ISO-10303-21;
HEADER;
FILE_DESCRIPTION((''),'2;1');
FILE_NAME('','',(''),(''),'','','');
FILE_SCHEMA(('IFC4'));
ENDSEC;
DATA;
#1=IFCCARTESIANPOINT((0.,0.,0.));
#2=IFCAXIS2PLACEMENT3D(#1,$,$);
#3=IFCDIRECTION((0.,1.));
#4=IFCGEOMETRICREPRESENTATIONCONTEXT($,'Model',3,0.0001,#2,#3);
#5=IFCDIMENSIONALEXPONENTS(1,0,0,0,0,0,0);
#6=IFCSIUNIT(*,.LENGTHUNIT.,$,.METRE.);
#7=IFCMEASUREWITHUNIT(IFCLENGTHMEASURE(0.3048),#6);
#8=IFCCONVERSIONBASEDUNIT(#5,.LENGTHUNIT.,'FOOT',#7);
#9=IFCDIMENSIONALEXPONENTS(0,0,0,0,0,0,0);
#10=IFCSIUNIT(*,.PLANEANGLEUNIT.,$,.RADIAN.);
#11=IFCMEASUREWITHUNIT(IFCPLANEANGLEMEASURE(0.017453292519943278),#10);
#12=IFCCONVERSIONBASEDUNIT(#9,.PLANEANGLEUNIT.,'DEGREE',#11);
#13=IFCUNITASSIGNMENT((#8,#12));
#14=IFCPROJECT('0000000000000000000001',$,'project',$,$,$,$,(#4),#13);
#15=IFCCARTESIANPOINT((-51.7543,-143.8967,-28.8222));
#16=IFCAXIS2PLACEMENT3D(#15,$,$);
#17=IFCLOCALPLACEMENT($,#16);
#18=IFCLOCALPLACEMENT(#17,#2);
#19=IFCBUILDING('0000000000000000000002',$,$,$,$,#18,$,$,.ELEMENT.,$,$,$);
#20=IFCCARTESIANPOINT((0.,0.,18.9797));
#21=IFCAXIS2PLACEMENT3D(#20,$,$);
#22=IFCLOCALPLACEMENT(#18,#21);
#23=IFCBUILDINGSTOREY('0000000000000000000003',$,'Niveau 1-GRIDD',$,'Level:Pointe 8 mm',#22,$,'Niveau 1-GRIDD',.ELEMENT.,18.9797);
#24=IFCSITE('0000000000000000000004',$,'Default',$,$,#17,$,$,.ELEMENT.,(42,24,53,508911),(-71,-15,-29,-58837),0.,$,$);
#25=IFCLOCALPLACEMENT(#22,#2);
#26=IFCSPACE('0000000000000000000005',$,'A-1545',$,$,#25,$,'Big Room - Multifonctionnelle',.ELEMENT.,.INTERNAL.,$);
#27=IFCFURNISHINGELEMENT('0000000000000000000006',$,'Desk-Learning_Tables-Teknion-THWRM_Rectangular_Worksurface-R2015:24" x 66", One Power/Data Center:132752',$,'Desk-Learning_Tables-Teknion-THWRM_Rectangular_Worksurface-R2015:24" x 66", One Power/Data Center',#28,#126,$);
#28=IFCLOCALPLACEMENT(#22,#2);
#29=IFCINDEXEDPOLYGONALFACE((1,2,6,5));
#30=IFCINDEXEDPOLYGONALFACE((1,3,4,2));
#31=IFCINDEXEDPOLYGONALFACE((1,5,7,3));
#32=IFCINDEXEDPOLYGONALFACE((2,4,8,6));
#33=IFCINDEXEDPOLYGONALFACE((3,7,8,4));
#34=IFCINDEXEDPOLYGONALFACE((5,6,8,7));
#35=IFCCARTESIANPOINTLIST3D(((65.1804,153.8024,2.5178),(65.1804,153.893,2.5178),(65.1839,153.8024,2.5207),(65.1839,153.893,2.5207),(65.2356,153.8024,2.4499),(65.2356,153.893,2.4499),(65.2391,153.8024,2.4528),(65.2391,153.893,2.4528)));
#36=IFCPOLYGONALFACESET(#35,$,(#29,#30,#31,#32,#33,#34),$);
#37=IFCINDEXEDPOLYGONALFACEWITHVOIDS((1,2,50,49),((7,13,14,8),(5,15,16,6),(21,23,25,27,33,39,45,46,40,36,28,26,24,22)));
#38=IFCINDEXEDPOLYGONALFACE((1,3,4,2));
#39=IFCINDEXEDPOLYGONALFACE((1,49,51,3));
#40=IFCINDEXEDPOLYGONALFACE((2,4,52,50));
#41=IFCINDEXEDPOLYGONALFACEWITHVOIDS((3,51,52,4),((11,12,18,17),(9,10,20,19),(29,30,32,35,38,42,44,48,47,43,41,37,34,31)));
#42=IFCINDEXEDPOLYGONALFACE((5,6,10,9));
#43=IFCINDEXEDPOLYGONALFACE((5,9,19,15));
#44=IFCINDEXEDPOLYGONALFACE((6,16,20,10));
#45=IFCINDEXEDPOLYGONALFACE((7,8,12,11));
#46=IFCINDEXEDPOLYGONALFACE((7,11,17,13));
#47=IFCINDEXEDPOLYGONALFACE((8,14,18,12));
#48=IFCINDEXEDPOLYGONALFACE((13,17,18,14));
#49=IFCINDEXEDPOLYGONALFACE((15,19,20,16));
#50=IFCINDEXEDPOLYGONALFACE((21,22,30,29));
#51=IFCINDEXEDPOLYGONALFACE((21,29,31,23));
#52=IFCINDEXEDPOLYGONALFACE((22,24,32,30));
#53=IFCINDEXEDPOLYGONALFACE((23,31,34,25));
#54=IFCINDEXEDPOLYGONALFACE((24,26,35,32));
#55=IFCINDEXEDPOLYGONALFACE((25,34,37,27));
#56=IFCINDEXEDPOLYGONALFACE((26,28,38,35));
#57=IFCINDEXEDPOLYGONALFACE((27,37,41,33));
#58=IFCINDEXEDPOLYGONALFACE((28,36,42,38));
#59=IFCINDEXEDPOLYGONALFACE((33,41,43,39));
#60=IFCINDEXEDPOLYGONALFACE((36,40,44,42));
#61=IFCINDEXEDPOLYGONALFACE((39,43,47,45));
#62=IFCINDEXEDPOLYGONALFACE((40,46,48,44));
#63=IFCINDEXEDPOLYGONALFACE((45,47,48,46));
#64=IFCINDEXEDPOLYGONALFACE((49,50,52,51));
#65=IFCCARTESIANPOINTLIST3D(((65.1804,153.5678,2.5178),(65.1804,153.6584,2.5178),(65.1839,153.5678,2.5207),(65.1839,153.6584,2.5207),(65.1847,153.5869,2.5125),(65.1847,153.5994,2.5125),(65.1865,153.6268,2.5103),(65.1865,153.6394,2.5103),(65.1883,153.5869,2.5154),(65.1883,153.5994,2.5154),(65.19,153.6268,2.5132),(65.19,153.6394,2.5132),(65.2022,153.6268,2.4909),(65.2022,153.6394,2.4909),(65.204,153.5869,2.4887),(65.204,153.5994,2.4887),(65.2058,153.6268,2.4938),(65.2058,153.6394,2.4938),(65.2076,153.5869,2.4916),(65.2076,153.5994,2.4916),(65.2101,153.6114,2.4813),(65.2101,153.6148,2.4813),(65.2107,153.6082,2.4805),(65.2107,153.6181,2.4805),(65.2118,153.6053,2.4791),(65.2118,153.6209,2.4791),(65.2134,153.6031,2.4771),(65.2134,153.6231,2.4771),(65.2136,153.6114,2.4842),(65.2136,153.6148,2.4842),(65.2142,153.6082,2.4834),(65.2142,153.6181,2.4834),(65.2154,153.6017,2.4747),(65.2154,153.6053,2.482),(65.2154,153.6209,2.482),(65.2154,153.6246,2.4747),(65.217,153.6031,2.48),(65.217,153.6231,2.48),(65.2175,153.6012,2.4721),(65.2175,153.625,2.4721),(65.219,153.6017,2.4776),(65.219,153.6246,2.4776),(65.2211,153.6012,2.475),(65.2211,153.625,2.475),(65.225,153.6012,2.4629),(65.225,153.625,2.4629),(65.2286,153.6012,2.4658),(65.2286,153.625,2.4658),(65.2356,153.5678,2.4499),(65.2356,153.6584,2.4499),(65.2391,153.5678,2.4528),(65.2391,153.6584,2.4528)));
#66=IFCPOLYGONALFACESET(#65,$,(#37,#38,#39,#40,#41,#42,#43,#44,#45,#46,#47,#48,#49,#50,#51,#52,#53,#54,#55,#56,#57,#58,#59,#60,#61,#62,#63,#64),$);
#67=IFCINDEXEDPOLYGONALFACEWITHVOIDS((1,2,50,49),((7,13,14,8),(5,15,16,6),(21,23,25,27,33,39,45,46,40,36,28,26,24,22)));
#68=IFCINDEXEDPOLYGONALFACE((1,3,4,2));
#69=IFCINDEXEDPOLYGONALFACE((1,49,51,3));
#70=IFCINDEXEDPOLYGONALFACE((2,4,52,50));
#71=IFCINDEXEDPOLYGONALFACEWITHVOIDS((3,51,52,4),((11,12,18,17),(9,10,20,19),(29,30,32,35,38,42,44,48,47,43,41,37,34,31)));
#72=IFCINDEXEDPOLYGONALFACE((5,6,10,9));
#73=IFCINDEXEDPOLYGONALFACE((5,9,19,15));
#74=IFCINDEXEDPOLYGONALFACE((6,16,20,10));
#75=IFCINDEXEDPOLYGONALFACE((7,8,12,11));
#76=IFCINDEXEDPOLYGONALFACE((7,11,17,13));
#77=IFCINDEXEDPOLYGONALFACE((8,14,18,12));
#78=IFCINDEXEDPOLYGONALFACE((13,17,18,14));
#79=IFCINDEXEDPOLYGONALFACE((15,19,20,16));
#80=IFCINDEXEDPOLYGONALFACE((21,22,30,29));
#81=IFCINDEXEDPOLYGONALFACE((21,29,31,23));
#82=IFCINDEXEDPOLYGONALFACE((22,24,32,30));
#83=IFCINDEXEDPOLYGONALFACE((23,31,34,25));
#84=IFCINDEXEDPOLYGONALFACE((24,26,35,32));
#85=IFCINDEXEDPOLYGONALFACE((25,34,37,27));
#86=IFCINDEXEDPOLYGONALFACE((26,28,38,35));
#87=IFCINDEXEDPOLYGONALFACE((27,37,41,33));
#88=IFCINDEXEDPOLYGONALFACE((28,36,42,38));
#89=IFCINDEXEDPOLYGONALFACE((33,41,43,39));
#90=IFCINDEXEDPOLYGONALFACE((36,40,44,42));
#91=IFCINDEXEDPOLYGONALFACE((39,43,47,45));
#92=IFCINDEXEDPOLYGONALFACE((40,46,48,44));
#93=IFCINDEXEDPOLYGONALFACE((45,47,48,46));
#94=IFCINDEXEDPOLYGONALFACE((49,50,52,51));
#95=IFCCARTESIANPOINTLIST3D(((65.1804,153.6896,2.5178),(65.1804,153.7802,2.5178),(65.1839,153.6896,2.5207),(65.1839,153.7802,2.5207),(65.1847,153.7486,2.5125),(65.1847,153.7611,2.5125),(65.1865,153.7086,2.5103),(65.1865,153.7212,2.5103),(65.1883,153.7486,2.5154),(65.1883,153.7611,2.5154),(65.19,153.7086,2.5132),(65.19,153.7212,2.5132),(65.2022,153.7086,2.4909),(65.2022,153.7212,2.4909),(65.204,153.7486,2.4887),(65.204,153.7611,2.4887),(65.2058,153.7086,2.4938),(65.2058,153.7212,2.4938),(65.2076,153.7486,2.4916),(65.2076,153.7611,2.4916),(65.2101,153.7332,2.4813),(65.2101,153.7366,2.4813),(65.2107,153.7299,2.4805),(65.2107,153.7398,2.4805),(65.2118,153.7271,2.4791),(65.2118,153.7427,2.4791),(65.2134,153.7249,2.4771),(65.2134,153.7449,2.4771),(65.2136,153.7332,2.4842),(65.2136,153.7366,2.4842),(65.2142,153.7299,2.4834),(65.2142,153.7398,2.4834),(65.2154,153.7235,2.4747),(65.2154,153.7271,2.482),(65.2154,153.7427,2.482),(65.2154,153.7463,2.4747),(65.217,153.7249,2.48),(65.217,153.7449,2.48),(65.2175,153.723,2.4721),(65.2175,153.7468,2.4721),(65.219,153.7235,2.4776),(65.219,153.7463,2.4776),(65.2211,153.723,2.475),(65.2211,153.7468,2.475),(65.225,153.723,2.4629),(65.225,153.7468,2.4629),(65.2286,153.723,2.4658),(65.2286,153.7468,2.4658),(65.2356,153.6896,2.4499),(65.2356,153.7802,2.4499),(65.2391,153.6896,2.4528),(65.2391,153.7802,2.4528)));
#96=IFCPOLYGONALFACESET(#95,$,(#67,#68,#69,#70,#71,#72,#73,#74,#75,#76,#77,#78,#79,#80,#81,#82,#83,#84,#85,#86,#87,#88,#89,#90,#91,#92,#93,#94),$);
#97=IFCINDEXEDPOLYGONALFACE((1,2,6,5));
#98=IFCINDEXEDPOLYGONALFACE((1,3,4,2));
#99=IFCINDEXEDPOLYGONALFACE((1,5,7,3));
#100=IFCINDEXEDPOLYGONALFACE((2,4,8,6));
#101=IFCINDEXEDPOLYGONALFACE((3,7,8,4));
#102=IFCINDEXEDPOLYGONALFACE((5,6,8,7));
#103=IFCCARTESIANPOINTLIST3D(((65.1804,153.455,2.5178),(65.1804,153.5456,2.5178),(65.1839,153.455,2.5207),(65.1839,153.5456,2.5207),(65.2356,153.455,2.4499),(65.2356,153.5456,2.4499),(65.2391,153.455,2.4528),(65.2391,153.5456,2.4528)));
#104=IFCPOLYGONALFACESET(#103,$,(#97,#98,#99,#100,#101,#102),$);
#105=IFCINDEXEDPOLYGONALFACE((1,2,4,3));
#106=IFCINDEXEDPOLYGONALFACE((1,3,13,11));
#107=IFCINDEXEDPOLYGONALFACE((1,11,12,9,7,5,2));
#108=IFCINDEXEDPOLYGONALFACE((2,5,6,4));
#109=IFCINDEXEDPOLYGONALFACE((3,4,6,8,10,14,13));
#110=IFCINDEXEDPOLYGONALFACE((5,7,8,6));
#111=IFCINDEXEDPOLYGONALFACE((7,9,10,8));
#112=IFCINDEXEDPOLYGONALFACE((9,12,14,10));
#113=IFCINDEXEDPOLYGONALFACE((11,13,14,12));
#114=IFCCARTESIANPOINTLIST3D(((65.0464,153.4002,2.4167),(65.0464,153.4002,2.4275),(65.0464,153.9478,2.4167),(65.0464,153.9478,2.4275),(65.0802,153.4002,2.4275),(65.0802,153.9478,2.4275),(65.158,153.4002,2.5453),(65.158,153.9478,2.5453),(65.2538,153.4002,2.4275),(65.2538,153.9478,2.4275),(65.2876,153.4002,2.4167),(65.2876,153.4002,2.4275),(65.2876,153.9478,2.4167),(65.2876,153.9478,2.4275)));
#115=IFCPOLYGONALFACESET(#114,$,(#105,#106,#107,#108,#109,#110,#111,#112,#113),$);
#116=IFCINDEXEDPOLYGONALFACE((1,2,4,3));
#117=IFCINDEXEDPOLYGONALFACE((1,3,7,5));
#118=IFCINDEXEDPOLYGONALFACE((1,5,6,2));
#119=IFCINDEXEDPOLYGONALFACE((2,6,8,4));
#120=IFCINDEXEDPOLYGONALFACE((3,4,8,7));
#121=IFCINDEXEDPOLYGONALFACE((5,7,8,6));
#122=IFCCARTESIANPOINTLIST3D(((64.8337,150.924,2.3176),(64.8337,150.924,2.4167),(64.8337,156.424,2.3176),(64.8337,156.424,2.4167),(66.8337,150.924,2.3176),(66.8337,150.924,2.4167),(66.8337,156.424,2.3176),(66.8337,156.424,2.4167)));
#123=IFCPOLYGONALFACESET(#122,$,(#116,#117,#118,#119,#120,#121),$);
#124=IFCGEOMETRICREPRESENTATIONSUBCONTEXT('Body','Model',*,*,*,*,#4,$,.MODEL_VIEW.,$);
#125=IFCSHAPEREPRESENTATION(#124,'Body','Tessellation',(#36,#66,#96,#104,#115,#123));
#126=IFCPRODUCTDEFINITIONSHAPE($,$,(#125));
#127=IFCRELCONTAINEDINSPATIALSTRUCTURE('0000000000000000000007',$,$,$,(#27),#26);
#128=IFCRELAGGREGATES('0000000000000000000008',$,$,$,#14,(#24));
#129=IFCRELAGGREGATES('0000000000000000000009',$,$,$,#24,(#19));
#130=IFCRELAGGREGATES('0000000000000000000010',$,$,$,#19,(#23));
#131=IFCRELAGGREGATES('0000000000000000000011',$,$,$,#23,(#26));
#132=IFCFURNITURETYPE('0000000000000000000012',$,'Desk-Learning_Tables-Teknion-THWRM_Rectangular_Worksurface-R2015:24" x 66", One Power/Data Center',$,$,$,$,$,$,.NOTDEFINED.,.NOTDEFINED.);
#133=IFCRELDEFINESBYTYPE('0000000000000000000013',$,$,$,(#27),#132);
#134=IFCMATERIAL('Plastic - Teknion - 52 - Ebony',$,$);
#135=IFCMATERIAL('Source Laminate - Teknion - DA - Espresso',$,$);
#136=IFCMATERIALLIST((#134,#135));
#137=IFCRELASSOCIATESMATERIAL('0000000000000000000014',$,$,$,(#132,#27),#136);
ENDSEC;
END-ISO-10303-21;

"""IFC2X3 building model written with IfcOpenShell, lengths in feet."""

from ifc_helpers import new_model, entity, si_unit, converted_unit, direction, frame, frame_2d, origin, place, context, subcontext, project, spatial, polyline, circle_curve, parameter, trimmed, segment, composite_curve, rectangle, outline, extrude, source, transform, mapped, material, material_list, type_object, type_shapes, element, save


model = new_model("IFC2X3")

# Units and contexts
model_context = context("Model", 3, precision=0.0001, world=origin(), true_north=direction((0.0, 1.0)))
body_context = subcontext(model_context, "Body", "Model", "MODEL_VIEW")
ifc_project = project(units=[converted_unit("LENGTHUNIT", "FOOT", entity("IfcLengthMeasure", 0.3048), si_unit("LENGTHUNIT", "METRE"), dimensions=[1, 0, 0, 0, 0, 0, 0]), converted_unit("PLANEANGLEUNIT", "DEGREE", entity("IfcPlaneAngleMeasure", 0.017453292519943278), si_unit("PLANEANGLEUNIT", "RADIAN"), dimensions=[0, 0, 0, 0, 0, 0, 0])], contexts=[model_context])

# Site, building, storey
site_placement = place(None, frame((-51.7543, -143.8967, -28.8222)))
site = spatial("IfcSite", under=ifc_project, at=site_placement, Name="Default", CompositionType="ELEMENT", RefLatitude=(42, 24, 53, 508911), RefLongitude=(-71, -15, -29, -58837), RefElevation=0.0)
building_placement = place(site_placement, origin())
building = spatial("IfcBuilding", under=site, at=building_placement, CompositionType="ELEMENT")
storey_placement = place(building_placement, frame((0.0, 0.0, 18.9797)))
storey = spatial("IfcBuildingStorey", under=building, at=storey_placement, Name="Niveau 1-GRIDD", ObjectType="Level:Pointe 8 mm", LongName="Niveau 1-GRIDD", CompositionType="ELEMENT", Elevation=18.9797)

# Shared definitions
space_placement = place(storey_placement, origin())
space = spatial("IfcSpace", under=storey, at=space_placement, Name="A-1545", LongName="Big Room - Multifonctionnelle", CompositionType="ELEMENT", InteriorOrExteriorSpace="INTERNAL")

# Furnishing element
ifc_material_1 = material(Name="Plastic - Teknion - 52 - Ebony")
ifc_material_2 = material(Name="Source Laminate - Teknion - DA - Espresso")
ifc_material_list_1 = material_list([ifc_material_1, ifc_material_2])
furniture_type_1 = type_object("IfcFurnitureType", Name="Desk-Learning_Tables-Teknion-THWRM_Rectangular_Worksurface-R2015:24\" x 66\", One Power/Data Center", AssemblyPlace="NOTDEFINED", material=ifc_material_list_1)
shared_shape_1 = source(origin(), body_context, "Body", "SweptSolid", [
    extrude(rectangle(XDim=0.0875, YDim=0.0046, at=frame_2d((0.0, 0.0), x_axis=(0.0, 1.0))), frame((0.1284, 0.6239, 2.4853), z_axis=(1.0, 0.0, 0.0), x_axis=(0.0, 0.776046, -0.630676)), (0.0, 0.0, 1.0), 0.0906),
    extrude(outline(polyline([(-0.0453, -0.0438), (0.0453, -0.0438), (0.0453, 0.0438), (-0.0453, 0.0438), (-0.0453, -0.0438)]), holes=[polyline([(-0.0262, -0.0063), (-0.0137, -0.0063), (-0.0137, -0.0369), (-0.0262, -0.0369), (-0.0262, -0.0063)]), polyline([(0.0137, -0.0341), (0.0137, -0.0091), (0.0262, -0.0091), (0.0262, -0.0341), (0.0137, -0.0341)]), composite_curve([segment(polyline([(-0.0119, 0.027), (0.0119, 0.027)]), True, "CONTINUOUS"), segment(polyline([(0.0119, 0.027), (0.0119, 0.0151)]), True, "CONTINUOUS"), segment(trimmed(circle_curve(frame_2d((0.0, 0.0151), x_axis=(0.0, -1.0)), 0.0119), [parameter(270.0)], [parameter(90.0)], True, "PARAMETER"), False, "CONTINUOUS"), segment(polyline([(-0.0119, 0.0151), (-0.0119, 0.027)]), True, "CONTINUOUS")], self_intersect=False)]), frame((-0.0609, 0.6221, 2.4867), z_axis=(0.0, 0.776046, -0.630676), x_axis=(1.0, 0.0, 0.0)), (0.0, 0.0, 1.0), 0.0046),
    extrude(outline(polyline([(-0.0438, -0.0453), (0.0438, -0.0453), (0.0438, 0.0453), (-0.0438, 0.0453), (-0.0438, -0.0453)]), holes=[polyline([(-0.0063, -0.0262), (-0.0369, -0.0262), (-0.0369, -0.0137), (-0.0063, -0.0137), (-0.0063, -0.0262)]), polyline([(-0.0341, 0.0137), (-0.0341, 0.0262), (-0.0091, 0.0262), (-0.0091, 0.0137), (-0.0341, 0.0137)]), composite_curve([segment(polyline([(0.027, -0.0119), (0.0151, -0.0119)]), True, "CONTINUOUS"), segment(trimmed(circle_curve(frame_2d((0.0151, 0.0), x_axis=(-1.0, 0.0)), 0.0119), [parameter(270.0)], [parameter(90.0)], True, "PARAMETER"), False, "CONTINUOUS"), segment(polyline([(0.0151, 0.0119), (0.027, 0.0119)]), True, "CONTINUOUS"), segment(polyline([(0.027, 0.0119), (0.027, -0.0119)]), True, "CONTINUOUS")], self_intersect=False)]), frame((0.0609, 0.6221, 2.4867), z_axis=(0.0, 0.776046, -0.630676), x_axis=(0.0, -0.630676, -0.776046)), (0.0, 0.0, 1.0), 0.0046),
    extrude(rectangle(XDim=0.0875, YDim=0.0046, at=frame_2d((0.0, 0.0), x_axis=(0.0, 1.0))), frame((-0.219, 0.6239, 2.4853), z_axis=(1.0, 0.0, 0.0), x_axis=(0.0, 0.776046, -0.630676)), (0.0, 0.0, 1.0), 0.0906),
    extrude(outline(polyline([(-0.0586, -0.0638), (0.0826, -0.0638), (0.0371, 0.0811), (0.0557, 0.1093), (0.0467, 0.1152), (-0.0862, -0.086), (-0.0772, -0.092), (-0.0586, -0.0638)])), frame((-0.2738, 0.6679, 2.4412), z_axis=(1.0, 0.0, 0.0), x_axis=(0.0, -0.551103, 0.834437)), (0.0, 0.0, 1.0), 0.5475),
    extrude(rectangle(XDim=5.5, YDim=2.0, at=frame_2d((0.0, 0.0), x_axis=(1.0, 0.0))), frame((0.0, 0.0, 2.3176), z_axis=(0.0, 0.0, 1.0), x_axis=(-1.0, 0.0, 0.0)), (0.0, 0.0, 1.0), 0.0991),
])
type_shapes(furniture_type_1, [shared_shape_1])
for number, where, z_axis, x_axis, name in (
    (1, (65.8337, 153.674, 0.0), (0.0, 0.0, 1.0), (0.0, 1.0, 0.0), "Desk-Learning_Tables-Teknion-THWRM_Rectangular_Worksurface-R2015:24\" x 66\", One Power/Data Center:132752"),
):
    element("IfcFurnishingElement", number, at=place(space_placement, frame(where, z_axis=z_axis, x_axis=x_axis)), inside=space, type_object=furniture_type_1, material=ifc_material_list_1, Name=name, ObjectType="Desk-Learning_Tables-Teknion-THWRM_Rectangular_Worksurface-R2015:24\" x 66\", One Power/Data Center", context=body_context, shape_type="MappedRepresentation", body=[
        mapped(shared_shape_1, transform((0.0, 0.0, 0.0), scale=1.0)),
    ])

save(model, "model.ifc")
